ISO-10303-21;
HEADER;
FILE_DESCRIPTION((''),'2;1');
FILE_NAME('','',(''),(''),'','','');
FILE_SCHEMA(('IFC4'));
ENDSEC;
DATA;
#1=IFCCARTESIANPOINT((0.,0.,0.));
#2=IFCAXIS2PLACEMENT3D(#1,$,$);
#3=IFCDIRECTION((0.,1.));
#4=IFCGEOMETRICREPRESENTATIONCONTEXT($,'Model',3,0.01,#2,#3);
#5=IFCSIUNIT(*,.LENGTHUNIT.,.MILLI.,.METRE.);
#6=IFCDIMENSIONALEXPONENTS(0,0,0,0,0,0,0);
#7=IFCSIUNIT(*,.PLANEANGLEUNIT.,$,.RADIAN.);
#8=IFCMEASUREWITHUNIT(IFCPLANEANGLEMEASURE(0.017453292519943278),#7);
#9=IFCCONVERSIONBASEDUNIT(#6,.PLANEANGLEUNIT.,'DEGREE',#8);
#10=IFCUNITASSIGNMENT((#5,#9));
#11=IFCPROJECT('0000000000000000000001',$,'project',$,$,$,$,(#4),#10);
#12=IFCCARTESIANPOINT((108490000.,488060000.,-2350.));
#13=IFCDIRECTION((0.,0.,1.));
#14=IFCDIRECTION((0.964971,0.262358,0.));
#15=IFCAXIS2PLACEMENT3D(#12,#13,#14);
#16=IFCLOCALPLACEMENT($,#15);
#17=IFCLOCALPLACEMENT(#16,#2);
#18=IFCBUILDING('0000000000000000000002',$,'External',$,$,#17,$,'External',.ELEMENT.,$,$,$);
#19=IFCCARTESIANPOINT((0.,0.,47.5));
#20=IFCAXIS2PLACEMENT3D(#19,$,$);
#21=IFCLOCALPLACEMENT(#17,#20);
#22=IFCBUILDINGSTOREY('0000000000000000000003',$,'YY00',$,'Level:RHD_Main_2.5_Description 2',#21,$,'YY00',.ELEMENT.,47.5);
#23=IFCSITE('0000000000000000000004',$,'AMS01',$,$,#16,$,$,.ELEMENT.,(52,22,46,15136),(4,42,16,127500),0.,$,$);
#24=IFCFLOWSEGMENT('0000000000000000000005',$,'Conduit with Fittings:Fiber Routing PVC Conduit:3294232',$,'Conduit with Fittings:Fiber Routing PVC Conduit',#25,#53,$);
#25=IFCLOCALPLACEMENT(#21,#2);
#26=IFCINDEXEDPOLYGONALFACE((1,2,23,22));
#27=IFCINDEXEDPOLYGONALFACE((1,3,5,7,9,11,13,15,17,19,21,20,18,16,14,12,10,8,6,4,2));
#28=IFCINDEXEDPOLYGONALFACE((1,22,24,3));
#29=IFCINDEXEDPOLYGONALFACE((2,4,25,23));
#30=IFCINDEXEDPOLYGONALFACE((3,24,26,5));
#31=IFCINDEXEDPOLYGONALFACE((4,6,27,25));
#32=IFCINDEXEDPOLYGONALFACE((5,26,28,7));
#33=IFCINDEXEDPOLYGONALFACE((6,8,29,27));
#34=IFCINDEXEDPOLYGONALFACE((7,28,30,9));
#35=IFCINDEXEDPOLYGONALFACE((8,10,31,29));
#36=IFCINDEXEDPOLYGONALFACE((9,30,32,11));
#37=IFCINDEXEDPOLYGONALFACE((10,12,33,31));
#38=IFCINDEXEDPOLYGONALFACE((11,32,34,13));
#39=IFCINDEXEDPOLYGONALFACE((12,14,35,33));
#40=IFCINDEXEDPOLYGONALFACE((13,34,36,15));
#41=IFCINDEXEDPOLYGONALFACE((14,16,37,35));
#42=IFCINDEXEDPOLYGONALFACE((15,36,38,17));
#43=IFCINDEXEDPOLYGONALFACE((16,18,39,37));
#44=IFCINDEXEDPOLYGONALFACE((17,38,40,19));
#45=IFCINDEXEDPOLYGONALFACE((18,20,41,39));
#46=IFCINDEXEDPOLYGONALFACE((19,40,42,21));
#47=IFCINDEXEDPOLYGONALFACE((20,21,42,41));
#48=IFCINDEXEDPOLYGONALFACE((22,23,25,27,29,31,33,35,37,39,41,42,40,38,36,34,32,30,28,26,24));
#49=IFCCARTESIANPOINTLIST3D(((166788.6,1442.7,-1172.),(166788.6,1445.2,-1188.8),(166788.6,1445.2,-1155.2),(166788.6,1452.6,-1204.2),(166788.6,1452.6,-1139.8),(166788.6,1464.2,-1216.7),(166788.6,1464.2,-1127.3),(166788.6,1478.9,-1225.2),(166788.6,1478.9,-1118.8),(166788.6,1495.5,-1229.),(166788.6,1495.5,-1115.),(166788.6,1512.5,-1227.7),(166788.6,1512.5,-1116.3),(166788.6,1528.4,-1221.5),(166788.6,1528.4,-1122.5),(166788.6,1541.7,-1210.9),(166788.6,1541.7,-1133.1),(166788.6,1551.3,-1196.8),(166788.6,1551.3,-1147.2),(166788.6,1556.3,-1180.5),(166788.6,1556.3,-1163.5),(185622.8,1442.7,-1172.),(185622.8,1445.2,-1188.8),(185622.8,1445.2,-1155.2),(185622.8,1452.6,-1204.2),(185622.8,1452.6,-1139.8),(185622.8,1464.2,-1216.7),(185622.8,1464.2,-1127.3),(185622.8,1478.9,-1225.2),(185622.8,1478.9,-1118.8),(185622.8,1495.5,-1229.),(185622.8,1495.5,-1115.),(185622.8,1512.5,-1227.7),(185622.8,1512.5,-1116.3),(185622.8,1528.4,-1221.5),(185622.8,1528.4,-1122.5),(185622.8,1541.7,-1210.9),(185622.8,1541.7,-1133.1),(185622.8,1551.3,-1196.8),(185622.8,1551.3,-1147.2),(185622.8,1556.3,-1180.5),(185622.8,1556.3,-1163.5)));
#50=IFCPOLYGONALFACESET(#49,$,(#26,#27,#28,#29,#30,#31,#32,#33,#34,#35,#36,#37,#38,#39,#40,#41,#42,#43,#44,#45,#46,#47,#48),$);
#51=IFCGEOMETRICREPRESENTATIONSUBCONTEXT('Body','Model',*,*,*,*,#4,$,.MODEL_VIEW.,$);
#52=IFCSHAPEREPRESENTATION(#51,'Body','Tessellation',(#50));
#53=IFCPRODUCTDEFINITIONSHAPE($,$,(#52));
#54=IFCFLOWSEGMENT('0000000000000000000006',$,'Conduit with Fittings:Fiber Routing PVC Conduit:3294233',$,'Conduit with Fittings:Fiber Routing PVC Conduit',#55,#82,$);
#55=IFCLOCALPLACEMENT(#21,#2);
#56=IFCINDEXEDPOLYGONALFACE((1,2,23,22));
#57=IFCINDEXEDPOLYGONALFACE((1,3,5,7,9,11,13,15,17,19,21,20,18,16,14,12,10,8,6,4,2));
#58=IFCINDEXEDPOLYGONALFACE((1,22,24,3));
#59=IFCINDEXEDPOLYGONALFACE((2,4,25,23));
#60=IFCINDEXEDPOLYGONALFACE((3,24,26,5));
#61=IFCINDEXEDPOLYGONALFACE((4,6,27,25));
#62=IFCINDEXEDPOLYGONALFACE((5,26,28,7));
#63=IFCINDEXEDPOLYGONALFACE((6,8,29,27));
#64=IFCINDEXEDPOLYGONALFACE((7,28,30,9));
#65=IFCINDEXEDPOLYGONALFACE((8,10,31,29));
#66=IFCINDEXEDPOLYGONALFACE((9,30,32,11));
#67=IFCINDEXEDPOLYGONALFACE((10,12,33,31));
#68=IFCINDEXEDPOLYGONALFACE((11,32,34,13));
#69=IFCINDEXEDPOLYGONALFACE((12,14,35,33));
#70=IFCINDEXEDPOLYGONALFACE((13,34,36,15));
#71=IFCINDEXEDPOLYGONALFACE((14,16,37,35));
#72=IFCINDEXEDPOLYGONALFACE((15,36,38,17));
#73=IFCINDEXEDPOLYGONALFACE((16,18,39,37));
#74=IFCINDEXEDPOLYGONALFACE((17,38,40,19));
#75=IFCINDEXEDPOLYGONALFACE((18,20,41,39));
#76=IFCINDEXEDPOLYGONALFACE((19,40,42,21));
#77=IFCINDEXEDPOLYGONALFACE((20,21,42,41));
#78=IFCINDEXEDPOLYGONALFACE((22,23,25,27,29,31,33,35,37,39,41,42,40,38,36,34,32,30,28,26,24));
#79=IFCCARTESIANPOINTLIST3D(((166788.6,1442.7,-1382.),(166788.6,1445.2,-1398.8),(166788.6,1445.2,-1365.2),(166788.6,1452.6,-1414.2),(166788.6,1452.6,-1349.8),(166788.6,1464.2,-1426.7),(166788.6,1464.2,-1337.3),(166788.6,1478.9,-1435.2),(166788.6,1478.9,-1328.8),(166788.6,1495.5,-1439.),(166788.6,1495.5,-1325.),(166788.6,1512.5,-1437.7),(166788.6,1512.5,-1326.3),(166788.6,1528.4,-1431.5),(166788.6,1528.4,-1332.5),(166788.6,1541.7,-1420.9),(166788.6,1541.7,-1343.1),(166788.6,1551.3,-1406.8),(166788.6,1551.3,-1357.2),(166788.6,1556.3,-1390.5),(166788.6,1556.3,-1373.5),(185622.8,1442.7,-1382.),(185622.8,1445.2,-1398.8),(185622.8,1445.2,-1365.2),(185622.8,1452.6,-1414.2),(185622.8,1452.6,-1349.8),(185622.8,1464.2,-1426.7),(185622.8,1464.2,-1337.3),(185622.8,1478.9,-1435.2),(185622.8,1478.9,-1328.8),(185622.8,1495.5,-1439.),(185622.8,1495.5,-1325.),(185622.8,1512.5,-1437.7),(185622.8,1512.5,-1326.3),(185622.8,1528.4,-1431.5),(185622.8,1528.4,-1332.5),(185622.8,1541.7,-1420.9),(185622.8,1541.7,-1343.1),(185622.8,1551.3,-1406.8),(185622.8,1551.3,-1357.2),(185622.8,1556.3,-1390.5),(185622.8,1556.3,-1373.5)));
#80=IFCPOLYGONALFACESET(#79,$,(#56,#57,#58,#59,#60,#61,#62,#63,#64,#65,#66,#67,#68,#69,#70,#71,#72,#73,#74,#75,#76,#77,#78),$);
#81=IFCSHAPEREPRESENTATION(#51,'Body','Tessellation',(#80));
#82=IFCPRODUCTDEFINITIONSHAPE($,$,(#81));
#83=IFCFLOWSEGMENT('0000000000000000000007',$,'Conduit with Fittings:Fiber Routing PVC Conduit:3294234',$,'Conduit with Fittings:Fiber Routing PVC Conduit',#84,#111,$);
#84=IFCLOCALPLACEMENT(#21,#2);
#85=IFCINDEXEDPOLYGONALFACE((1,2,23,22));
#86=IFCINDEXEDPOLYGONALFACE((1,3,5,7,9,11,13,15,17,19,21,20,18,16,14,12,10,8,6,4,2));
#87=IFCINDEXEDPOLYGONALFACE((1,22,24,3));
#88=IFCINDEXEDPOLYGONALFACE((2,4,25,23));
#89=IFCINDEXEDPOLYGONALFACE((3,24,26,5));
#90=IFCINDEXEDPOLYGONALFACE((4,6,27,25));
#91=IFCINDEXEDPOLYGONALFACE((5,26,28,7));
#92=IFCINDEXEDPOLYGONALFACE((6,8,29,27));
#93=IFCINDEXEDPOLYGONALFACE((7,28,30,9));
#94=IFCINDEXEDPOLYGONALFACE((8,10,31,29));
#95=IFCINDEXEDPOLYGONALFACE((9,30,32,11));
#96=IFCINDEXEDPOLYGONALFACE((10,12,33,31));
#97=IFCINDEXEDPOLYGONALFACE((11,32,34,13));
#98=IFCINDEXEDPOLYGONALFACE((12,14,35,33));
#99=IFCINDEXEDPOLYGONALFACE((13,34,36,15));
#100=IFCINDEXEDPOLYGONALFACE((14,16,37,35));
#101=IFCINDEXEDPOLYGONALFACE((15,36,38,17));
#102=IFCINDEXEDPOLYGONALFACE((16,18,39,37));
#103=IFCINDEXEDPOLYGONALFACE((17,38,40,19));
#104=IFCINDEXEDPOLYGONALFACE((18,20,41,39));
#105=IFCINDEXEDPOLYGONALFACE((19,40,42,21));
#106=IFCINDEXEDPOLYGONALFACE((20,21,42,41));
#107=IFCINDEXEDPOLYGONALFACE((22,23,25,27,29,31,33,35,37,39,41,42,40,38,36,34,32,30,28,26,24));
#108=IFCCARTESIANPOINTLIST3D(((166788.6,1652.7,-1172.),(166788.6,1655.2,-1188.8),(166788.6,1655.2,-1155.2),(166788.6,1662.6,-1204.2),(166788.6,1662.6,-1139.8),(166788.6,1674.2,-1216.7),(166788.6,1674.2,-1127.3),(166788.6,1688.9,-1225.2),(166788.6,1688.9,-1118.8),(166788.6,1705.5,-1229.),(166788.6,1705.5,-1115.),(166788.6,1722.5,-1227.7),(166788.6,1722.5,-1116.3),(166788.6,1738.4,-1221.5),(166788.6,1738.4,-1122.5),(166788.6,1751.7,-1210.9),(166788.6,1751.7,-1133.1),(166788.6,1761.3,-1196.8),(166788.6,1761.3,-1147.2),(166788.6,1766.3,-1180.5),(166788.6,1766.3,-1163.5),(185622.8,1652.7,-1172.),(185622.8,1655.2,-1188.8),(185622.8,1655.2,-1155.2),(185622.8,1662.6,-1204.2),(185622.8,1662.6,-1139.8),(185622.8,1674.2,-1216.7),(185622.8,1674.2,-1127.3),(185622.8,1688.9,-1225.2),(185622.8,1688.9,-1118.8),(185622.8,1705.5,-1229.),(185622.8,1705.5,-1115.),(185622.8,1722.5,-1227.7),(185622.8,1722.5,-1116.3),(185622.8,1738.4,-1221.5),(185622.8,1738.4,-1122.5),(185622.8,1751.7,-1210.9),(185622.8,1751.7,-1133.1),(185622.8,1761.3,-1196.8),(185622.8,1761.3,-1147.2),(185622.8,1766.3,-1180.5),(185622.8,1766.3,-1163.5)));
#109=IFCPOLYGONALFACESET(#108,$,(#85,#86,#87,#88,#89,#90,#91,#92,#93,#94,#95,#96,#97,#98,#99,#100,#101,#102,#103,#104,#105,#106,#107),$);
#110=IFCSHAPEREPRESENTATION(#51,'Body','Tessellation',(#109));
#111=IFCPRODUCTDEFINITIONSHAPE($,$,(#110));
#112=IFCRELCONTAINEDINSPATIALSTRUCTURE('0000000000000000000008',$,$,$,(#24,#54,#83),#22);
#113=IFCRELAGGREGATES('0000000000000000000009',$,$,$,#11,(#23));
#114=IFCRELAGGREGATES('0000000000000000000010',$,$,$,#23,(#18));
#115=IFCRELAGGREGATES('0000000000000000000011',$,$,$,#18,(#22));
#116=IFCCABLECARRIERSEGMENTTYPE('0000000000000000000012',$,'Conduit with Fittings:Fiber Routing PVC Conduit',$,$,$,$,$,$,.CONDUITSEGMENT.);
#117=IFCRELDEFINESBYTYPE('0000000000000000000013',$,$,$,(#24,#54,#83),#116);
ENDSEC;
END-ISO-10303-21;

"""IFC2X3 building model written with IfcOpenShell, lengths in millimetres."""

from ifc_helpers import new_model, entity, si_unit, converted_unit, direction, frame, frame_2d, origin, origin_2d_with_axis, place, context, subcontext, project, spatial, circle, extrude, type_object, element, save


model = new_model("IFC2X3")

# Units and contexts
model_context = context("Model", 3, precision=0.01, world=origin(), true_north=direction((0.0, 1.0)))
body_context = subcontext(model_context, "Body", "Model", "MODEL_VIEW")
ifc_project = project(units=[si_unit("LENGTHUNIT", "METRE", prefix="MILLI"), converted_unit("PLANEANGLEUNIT", "DEGREE", entity("IfcPlaneAngleMeasure", 0.017453292519943278), si_unit("PLANEANGLEUNIT", "RADIAN"), dimensions=[0, 0, 0, 0, 0, 0, 0])], contexts=[model_context])

# Site, building, storey
site_placement = place(None, frame((108490000.0, 488060000.0, -2350.0), z_axis=(0.0, 0.0, 1.0), x_axis=(0.964971, 0.262358, 0.0)))
site = spatial("IfcSite", under=ifc_project, at=site_placement, Name="AMS01", CompositionType="ELEMENT", RefLatitude=(52, 22, 46, 15136), RefLongitude=(4, 42, 16, 127500), RefElevation=0.0)
building_placement = place(site_placement, origin())
building = spatial("IfcBuilding", under=site, at=building_placement, Name="External", LongName="External", CompositionType="ELEMENT")
storey_placement = place(building_placement, frame((0.0, 0.0, 47.5)))
storey = spatial("IfcBuildingStorey", under=building, at=storey_placement, Name="YY00", ObjectType="Level:RHD_Main_2.5_Description 2", LongName="YY00", CompositionType="ELEMENT", Elevation=47.5)

# Flow segments
cable_carrier_segment_type = type_object("IfcCableCarrierSegmentType", Name="Conduit with Fittings:Fiber Routing PVC Conduit", PredefinedType="CONDUITSEGMENT")
flow_segment_1_placement = place(storey_placement, origin())
element("IfcFlowSegment", 1, at=flow_segment_1_placement, inside=storey, type_object=cable_carrier_segment_type, Name="Conduit with Fittings:Fiber Routing PVC Conduit:3294232", ObjectType="Conduit with Fittings:Fiber Routing PVC Conduit", context=body_context, shape_type="SweptSolid", body=[
    extrude(circle(Radius=57.2, at=frame_2d((0.0, 0.0), x_axis=(1.0, 0.0))), frame((166788.6, 1499.8, -1172.0), z_axis=(1.0, 0.0, 0.0), x_axis=(0.0, -1.0, 0.0)), (0.0, 0.0, 1.0), 18834.3),
])
flow_segment_2_placement = place(storey_placement, origin())
element("IfcFlowSegment", 2, at=flow_segment_2_placement, inside=storey, type_object=cable_carrier_segment_type, Name="Conduit with Fittings:Fiber Routing PVC Conduit:3294233", ObjectType="Conduit with Fittings:Fiber Routing PVC Conduit", context=body_context, shape_type="SweptSolid", body=[
    extrude(circle(Radius=57.2, at=frame_2d((0.0, 0.0), x_axis=(1.0, 0.0))), frame((166788.6, 1499.8, -1382.0), z_axis=(1.0, 0.0, 0.0), x_axis=(0.0, -1.0, 0.0)), (0.0, 0.0, 1.0), 18834.3),
])
flow_segment_3_placement = place(storey_placement, origin())
element("IfcFlowSegment", 3, at=flow_segment_3_placement, inside=storey, type_object=cable_carrier_segment_type, Name="Conduit with Fittings:Fiber Routing PVC Conduit:3294234", ObjectType="Conduit with Fittings:Fiber Routing PVC Conduit", context=body_context, shape_type="SweptSolid", body=[
    extrude(circle(Radius=57.2, at=origin_2d_with_axis()), frame((166788.6, 1709.8, -1172.0), z_axis=(1.0, 0.0, 0.0), x_axis=(0.0, -1.0, 0.0)), (0.0, 0.0, 1.0), 18834.3),
])

save(model, "model.ifc")
